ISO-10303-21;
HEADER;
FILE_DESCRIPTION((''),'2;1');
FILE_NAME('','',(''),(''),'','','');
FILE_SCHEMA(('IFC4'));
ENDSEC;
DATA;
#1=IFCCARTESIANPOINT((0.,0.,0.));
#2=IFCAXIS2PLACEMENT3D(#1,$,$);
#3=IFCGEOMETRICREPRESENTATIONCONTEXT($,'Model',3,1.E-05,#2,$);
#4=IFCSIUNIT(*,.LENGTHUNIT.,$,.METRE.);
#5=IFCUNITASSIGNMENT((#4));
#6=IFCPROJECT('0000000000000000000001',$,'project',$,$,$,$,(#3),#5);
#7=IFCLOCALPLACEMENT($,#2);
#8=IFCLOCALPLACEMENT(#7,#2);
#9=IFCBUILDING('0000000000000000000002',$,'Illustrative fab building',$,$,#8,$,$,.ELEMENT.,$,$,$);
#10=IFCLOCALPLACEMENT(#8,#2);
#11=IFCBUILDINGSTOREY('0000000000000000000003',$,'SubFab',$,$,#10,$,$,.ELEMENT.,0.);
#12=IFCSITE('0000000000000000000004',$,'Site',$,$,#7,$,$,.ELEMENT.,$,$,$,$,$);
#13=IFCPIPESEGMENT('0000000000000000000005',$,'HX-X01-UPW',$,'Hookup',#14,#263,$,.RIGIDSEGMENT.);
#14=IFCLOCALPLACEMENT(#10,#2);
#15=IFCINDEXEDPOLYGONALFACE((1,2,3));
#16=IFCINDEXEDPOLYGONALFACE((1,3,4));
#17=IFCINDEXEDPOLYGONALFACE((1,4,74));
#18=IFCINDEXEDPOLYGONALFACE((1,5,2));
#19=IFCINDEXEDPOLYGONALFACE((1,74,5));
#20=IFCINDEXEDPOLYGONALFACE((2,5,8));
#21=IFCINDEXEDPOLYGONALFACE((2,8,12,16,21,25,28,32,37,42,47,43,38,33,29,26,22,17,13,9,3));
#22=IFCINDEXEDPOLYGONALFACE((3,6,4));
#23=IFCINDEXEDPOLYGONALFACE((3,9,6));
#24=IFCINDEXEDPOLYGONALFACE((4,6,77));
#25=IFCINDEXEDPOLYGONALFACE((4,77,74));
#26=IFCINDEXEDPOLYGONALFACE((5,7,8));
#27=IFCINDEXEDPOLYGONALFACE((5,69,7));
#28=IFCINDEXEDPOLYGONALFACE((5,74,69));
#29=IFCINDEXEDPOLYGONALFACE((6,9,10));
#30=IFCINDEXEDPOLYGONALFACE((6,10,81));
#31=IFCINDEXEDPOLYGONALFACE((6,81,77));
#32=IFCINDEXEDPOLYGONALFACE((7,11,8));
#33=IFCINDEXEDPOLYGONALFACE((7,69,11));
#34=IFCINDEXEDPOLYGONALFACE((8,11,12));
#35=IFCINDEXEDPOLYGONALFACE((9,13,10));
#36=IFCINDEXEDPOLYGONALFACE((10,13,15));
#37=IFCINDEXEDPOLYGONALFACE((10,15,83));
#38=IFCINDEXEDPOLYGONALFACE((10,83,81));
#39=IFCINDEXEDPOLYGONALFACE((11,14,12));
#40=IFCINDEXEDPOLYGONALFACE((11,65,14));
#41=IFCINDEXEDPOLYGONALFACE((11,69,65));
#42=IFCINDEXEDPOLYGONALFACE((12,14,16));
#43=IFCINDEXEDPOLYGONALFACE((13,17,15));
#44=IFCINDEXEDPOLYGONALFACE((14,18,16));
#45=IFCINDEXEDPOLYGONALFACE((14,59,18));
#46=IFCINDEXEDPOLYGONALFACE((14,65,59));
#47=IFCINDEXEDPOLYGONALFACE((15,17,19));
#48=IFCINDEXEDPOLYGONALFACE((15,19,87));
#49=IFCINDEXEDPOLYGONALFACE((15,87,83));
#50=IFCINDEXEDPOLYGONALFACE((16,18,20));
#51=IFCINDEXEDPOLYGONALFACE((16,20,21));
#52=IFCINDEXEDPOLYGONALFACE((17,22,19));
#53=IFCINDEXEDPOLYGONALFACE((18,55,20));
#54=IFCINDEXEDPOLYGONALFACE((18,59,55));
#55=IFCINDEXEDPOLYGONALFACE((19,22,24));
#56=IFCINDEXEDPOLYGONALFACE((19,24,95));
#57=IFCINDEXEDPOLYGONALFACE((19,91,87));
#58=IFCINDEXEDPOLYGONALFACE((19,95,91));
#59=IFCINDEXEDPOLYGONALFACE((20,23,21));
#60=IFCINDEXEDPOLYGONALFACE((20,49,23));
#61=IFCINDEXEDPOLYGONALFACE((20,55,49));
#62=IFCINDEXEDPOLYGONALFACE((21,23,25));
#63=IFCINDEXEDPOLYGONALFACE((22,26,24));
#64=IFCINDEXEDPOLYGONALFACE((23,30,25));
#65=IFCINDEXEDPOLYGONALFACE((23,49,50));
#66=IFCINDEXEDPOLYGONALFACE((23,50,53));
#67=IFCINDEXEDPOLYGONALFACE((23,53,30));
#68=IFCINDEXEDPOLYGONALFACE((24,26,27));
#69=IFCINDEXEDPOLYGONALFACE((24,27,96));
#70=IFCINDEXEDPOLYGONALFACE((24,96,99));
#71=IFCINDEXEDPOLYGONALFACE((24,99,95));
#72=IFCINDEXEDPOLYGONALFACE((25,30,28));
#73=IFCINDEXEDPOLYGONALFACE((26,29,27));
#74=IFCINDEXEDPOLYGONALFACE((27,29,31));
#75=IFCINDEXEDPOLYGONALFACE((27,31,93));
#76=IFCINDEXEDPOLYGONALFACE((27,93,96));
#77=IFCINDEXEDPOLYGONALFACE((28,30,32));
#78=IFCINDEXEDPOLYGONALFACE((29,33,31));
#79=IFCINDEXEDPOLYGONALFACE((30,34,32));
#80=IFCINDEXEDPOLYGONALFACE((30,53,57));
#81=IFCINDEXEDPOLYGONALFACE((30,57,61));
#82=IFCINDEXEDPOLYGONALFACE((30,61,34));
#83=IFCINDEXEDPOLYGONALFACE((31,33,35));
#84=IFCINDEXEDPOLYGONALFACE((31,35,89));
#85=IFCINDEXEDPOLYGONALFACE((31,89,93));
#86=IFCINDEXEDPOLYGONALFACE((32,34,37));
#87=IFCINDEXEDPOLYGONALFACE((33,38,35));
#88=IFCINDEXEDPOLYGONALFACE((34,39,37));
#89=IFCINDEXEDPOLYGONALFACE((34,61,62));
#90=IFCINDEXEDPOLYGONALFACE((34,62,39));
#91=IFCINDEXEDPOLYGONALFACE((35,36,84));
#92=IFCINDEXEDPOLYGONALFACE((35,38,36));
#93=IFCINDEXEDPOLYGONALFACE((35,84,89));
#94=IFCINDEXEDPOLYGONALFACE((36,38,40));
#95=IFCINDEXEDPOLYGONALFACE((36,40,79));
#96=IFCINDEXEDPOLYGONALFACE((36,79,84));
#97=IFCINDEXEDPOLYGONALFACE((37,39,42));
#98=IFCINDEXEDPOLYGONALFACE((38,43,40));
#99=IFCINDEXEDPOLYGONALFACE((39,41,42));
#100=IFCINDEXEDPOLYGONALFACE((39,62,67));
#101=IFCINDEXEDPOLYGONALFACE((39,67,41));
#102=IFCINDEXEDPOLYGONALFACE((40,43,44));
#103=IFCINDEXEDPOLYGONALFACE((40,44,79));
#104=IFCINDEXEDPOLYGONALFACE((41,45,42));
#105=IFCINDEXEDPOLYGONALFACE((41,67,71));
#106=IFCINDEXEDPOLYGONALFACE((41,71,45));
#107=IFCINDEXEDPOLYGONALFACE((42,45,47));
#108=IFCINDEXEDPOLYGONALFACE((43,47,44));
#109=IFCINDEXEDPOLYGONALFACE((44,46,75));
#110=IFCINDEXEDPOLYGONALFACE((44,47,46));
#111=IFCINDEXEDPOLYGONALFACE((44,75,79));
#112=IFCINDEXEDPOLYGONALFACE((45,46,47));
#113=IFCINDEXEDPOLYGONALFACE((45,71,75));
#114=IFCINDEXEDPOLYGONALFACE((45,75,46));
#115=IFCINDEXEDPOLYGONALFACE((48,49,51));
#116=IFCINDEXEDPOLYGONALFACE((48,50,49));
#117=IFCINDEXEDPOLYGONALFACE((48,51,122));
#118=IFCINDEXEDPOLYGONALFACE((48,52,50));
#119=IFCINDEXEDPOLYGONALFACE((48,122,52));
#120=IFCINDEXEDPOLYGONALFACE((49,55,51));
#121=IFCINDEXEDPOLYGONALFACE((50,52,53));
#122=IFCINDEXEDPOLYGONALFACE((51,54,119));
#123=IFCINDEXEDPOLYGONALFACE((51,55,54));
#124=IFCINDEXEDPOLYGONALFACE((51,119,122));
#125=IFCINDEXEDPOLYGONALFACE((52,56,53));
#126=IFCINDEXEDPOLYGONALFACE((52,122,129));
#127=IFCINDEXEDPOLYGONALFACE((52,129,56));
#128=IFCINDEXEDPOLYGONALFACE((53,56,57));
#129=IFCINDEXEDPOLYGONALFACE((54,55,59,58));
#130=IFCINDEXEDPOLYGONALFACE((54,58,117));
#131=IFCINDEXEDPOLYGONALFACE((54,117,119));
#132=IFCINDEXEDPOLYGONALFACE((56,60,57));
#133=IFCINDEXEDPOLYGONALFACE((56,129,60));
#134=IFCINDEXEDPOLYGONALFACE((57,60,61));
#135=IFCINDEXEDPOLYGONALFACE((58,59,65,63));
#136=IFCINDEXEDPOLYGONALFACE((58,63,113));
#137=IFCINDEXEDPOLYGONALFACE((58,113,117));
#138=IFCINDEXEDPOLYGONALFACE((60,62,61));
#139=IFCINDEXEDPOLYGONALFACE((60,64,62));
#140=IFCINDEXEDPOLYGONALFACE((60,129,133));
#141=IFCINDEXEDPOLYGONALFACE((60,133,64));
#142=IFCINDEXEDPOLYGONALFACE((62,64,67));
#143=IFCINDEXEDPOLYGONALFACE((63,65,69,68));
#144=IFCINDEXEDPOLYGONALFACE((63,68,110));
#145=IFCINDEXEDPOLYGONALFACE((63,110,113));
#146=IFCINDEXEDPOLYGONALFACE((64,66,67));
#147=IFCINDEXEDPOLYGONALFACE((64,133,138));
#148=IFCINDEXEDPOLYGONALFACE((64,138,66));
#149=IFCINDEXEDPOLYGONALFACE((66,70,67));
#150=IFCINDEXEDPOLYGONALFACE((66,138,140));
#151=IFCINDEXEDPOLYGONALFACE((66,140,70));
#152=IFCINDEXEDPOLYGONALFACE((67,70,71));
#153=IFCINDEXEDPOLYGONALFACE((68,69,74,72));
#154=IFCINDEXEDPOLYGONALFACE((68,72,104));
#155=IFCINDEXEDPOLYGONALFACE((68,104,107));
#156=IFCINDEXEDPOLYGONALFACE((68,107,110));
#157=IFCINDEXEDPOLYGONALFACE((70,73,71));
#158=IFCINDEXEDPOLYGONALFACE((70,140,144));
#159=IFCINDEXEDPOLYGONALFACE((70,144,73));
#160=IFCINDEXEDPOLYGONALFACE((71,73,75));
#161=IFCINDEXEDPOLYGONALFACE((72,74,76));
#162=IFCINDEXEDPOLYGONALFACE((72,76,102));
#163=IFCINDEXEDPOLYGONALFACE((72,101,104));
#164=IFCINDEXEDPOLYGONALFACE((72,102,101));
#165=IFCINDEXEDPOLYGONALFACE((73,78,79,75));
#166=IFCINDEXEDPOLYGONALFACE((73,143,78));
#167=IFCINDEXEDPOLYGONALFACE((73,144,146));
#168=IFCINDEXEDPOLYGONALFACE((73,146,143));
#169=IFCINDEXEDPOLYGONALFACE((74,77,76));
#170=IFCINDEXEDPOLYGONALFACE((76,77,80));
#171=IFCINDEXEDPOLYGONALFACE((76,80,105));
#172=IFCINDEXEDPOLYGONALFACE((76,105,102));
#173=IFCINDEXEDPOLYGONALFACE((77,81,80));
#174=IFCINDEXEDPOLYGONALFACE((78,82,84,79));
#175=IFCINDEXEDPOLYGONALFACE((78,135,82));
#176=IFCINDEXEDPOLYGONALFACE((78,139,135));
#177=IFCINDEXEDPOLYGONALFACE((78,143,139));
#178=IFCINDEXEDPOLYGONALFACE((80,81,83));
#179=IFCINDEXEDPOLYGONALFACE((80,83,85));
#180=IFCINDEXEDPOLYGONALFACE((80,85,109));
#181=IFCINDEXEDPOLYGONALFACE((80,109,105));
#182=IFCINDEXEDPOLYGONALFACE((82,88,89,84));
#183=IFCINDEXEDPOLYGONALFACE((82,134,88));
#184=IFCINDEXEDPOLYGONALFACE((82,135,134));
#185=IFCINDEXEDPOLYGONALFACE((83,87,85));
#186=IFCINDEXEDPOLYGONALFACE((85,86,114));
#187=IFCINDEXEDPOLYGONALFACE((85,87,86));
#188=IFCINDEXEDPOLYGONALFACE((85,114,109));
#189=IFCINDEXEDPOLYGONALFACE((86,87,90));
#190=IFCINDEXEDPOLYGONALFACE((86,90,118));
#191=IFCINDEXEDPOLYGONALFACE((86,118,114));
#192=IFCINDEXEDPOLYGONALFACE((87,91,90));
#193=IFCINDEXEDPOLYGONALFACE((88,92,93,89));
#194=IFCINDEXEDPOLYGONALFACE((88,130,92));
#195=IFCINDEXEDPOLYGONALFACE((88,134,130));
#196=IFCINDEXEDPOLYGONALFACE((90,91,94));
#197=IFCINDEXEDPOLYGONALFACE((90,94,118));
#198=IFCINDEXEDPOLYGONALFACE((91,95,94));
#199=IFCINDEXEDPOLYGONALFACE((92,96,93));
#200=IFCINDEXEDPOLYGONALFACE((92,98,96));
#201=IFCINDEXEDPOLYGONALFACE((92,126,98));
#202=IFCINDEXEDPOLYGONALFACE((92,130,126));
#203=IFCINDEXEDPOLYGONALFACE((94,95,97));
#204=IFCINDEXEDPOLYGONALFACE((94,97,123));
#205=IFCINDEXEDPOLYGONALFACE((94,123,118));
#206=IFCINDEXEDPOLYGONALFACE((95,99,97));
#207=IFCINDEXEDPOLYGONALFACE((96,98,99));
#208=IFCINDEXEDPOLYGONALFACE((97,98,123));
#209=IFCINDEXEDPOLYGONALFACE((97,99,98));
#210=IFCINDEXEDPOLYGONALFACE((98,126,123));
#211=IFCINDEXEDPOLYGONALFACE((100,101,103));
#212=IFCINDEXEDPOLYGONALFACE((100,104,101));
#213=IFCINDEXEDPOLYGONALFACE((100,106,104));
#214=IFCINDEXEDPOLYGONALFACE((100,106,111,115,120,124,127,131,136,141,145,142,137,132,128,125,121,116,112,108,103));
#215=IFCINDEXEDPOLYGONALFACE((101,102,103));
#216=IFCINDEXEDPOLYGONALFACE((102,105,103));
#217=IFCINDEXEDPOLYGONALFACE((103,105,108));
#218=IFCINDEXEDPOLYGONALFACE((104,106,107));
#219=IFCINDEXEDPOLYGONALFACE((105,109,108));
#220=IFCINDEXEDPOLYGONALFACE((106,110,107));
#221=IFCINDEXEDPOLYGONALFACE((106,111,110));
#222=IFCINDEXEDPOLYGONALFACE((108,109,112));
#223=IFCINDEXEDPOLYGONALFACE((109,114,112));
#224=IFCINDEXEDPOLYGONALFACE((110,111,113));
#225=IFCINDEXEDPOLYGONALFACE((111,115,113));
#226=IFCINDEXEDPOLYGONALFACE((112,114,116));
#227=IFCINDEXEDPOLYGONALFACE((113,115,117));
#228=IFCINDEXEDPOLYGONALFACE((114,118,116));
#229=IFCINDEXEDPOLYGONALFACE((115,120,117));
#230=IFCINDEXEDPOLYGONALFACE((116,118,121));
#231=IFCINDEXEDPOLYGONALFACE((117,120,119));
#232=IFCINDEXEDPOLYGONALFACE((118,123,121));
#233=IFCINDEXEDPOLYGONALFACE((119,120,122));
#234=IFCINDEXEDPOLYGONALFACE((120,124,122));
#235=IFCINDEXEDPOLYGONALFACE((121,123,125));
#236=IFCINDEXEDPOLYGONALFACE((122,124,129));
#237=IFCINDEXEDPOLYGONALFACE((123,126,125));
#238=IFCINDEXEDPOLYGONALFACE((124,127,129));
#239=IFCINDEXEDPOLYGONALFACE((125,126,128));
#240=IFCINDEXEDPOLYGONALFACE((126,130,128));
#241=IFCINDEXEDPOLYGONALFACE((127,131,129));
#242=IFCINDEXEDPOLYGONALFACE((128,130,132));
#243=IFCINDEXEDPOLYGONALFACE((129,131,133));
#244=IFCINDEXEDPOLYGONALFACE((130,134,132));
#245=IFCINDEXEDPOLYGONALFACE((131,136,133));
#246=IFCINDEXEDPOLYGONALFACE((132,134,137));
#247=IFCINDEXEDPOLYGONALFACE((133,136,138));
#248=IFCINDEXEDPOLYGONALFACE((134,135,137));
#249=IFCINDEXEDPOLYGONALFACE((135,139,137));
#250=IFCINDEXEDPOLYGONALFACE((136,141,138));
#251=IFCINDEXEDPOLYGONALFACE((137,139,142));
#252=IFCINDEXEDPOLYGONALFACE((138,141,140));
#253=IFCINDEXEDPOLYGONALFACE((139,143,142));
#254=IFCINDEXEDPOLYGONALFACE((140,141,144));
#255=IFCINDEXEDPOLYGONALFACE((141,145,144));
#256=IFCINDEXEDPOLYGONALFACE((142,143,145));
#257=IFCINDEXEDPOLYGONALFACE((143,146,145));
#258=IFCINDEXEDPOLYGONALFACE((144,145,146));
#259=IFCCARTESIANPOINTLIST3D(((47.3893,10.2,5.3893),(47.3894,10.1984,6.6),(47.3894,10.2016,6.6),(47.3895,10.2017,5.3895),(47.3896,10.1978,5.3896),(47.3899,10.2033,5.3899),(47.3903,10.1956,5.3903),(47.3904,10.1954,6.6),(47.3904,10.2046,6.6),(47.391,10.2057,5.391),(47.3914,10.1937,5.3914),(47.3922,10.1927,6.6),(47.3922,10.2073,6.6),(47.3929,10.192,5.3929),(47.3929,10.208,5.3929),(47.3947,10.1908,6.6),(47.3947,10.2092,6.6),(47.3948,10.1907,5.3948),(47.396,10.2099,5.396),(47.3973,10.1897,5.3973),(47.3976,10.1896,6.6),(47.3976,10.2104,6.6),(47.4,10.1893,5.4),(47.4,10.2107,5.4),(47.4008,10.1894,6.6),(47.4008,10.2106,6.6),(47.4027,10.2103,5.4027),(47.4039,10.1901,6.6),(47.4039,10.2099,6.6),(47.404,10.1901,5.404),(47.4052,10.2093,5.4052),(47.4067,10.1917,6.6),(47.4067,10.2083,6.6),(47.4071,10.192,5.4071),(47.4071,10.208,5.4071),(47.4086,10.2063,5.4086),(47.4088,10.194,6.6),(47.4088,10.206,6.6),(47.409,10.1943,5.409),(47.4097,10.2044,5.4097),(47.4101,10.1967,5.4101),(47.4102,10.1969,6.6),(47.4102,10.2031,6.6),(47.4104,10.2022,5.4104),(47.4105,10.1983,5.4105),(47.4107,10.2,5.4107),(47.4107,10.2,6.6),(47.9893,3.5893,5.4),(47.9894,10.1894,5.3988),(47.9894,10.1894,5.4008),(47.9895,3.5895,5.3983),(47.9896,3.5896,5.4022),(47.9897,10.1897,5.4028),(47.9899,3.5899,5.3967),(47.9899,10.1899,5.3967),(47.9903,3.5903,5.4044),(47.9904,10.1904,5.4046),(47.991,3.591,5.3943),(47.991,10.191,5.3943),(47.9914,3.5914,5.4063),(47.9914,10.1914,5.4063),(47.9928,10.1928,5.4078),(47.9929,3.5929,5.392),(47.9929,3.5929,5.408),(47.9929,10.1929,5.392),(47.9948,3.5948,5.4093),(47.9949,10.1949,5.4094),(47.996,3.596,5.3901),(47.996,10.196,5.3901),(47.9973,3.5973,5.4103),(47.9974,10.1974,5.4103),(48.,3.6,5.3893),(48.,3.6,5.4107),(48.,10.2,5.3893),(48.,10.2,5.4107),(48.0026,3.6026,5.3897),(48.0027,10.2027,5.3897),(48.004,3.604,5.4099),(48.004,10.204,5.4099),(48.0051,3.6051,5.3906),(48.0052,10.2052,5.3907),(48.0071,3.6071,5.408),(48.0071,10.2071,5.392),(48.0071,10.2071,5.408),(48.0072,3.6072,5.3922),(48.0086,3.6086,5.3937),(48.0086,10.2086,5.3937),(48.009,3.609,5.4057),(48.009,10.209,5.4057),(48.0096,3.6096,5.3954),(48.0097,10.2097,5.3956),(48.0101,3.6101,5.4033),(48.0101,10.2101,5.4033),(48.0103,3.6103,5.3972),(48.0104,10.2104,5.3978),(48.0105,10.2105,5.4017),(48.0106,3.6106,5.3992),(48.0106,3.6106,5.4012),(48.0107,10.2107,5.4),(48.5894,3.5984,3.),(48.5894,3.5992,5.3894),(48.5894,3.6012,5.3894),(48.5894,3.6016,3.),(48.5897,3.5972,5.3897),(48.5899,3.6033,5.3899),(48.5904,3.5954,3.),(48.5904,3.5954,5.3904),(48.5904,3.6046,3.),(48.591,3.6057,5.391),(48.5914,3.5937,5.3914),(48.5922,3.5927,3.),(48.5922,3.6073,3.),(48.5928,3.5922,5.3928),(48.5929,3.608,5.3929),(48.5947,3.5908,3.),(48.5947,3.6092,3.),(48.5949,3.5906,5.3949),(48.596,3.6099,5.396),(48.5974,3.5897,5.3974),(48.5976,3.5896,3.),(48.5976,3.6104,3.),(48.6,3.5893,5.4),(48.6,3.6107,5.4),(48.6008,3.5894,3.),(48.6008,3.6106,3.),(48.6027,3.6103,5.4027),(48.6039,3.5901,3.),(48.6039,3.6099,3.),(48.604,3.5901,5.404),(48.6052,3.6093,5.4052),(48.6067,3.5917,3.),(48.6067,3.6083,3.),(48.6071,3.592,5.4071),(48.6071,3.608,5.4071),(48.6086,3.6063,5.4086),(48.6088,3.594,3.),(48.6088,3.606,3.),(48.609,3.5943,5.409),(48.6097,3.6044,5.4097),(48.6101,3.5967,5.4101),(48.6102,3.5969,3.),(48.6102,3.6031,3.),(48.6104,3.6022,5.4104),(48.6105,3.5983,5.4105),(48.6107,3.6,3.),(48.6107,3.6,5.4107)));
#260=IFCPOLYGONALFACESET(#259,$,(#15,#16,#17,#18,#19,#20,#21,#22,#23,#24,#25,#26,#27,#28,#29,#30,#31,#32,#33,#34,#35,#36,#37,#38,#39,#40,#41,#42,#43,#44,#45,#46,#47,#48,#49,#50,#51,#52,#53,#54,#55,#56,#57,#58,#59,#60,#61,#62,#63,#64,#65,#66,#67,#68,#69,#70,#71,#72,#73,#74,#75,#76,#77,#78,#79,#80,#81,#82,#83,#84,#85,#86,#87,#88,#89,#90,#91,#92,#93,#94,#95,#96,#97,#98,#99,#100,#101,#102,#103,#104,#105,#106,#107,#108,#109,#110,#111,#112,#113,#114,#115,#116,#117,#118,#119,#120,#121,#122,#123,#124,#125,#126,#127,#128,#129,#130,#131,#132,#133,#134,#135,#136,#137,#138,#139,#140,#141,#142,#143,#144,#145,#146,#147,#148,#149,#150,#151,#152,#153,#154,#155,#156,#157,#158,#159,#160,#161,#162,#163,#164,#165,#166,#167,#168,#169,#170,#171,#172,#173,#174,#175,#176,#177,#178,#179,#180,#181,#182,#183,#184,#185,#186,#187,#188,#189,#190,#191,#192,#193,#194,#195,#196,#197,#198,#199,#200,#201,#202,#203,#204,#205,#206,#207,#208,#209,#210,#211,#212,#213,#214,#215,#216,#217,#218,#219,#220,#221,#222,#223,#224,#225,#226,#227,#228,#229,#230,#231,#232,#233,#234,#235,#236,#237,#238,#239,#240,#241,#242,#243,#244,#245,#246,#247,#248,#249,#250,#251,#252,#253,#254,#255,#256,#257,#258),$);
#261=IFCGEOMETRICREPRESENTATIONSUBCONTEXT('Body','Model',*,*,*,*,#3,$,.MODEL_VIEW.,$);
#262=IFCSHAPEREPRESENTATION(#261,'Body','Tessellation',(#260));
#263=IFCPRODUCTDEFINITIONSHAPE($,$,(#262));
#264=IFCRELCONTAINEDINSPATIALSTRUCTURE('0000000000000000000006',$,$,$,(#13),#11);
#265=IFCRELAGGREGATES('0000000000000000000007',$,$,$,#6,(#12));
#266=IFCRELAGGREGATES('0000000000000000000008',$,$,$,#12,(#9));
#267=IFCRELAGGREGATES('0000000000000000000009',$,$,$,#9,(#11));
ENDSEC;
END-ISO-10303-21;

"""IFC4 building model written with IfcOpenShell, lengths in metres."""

from ifc_helpers import new_model, entity, si_unit, origin, place, context, subcontext, project, spatial, element, save


model = new_model("IFC4")

# Units and contexts
model_context = context("Model", 3, precision=1e-05, world=origin())
body_context = subcontext(model_context, "Body", "Model", "MODEL_VIEW")
ifc_project = project(units=[si_unit("LENGTHUNIT", "METRE")], contexts=[model_context])

# Site, building, storey
site_placement = place(None, origin())
site = spatial("IfcSite", under=ifc_project, at=site_placement, Name="Site", CompositionType="ELEMENT")
building_placement = place(site_placement, origin())
building = spatial("IfcBuilding", under=site, at=building_placement, Name="Illustrative fab building", CompositionType="ELEMENT")
storey_placement = place(building_placement, origin())
storey = spatial("IfcBuildingStorey", under=building, at=storey_placement, Name="SubFab", CompositionType="ELEMENT", Elevation=0.0)

# Pipe segment
pipe_segment_1_placement = place(storey_placement, origin())
element("IfcPipeSegment", 1, at=pipe_segment_1_placement, inside=storey, Name="HX-X01-UPW", ObjectType="Hookup", PredefinedType="RIGIDSEGMENT", context=body_context, shape_type="AdvancedSweptSolid", body=[
    entity("IfcSweptDiskSolid", entity("IfcPolyline", [entity("IfcCartesianPoint", [48.6, 3.6, 3.0]), entity("IfcCartesianPoint", [48.6, 3.6, 5.4]), entity("IfcCartesianPoint", [48.0, 3.6, 5.4]), entity("IfcCartesianPoint", [48.0, 10.2, 5.4]), entity("IfcCartesianPoint", [47.4, 10.2, 5.4]), entity("IfcCartesianPoint", [47.4, 10.2, 6.6])]), 0.0107),
])

save(model, "model.ifc")
